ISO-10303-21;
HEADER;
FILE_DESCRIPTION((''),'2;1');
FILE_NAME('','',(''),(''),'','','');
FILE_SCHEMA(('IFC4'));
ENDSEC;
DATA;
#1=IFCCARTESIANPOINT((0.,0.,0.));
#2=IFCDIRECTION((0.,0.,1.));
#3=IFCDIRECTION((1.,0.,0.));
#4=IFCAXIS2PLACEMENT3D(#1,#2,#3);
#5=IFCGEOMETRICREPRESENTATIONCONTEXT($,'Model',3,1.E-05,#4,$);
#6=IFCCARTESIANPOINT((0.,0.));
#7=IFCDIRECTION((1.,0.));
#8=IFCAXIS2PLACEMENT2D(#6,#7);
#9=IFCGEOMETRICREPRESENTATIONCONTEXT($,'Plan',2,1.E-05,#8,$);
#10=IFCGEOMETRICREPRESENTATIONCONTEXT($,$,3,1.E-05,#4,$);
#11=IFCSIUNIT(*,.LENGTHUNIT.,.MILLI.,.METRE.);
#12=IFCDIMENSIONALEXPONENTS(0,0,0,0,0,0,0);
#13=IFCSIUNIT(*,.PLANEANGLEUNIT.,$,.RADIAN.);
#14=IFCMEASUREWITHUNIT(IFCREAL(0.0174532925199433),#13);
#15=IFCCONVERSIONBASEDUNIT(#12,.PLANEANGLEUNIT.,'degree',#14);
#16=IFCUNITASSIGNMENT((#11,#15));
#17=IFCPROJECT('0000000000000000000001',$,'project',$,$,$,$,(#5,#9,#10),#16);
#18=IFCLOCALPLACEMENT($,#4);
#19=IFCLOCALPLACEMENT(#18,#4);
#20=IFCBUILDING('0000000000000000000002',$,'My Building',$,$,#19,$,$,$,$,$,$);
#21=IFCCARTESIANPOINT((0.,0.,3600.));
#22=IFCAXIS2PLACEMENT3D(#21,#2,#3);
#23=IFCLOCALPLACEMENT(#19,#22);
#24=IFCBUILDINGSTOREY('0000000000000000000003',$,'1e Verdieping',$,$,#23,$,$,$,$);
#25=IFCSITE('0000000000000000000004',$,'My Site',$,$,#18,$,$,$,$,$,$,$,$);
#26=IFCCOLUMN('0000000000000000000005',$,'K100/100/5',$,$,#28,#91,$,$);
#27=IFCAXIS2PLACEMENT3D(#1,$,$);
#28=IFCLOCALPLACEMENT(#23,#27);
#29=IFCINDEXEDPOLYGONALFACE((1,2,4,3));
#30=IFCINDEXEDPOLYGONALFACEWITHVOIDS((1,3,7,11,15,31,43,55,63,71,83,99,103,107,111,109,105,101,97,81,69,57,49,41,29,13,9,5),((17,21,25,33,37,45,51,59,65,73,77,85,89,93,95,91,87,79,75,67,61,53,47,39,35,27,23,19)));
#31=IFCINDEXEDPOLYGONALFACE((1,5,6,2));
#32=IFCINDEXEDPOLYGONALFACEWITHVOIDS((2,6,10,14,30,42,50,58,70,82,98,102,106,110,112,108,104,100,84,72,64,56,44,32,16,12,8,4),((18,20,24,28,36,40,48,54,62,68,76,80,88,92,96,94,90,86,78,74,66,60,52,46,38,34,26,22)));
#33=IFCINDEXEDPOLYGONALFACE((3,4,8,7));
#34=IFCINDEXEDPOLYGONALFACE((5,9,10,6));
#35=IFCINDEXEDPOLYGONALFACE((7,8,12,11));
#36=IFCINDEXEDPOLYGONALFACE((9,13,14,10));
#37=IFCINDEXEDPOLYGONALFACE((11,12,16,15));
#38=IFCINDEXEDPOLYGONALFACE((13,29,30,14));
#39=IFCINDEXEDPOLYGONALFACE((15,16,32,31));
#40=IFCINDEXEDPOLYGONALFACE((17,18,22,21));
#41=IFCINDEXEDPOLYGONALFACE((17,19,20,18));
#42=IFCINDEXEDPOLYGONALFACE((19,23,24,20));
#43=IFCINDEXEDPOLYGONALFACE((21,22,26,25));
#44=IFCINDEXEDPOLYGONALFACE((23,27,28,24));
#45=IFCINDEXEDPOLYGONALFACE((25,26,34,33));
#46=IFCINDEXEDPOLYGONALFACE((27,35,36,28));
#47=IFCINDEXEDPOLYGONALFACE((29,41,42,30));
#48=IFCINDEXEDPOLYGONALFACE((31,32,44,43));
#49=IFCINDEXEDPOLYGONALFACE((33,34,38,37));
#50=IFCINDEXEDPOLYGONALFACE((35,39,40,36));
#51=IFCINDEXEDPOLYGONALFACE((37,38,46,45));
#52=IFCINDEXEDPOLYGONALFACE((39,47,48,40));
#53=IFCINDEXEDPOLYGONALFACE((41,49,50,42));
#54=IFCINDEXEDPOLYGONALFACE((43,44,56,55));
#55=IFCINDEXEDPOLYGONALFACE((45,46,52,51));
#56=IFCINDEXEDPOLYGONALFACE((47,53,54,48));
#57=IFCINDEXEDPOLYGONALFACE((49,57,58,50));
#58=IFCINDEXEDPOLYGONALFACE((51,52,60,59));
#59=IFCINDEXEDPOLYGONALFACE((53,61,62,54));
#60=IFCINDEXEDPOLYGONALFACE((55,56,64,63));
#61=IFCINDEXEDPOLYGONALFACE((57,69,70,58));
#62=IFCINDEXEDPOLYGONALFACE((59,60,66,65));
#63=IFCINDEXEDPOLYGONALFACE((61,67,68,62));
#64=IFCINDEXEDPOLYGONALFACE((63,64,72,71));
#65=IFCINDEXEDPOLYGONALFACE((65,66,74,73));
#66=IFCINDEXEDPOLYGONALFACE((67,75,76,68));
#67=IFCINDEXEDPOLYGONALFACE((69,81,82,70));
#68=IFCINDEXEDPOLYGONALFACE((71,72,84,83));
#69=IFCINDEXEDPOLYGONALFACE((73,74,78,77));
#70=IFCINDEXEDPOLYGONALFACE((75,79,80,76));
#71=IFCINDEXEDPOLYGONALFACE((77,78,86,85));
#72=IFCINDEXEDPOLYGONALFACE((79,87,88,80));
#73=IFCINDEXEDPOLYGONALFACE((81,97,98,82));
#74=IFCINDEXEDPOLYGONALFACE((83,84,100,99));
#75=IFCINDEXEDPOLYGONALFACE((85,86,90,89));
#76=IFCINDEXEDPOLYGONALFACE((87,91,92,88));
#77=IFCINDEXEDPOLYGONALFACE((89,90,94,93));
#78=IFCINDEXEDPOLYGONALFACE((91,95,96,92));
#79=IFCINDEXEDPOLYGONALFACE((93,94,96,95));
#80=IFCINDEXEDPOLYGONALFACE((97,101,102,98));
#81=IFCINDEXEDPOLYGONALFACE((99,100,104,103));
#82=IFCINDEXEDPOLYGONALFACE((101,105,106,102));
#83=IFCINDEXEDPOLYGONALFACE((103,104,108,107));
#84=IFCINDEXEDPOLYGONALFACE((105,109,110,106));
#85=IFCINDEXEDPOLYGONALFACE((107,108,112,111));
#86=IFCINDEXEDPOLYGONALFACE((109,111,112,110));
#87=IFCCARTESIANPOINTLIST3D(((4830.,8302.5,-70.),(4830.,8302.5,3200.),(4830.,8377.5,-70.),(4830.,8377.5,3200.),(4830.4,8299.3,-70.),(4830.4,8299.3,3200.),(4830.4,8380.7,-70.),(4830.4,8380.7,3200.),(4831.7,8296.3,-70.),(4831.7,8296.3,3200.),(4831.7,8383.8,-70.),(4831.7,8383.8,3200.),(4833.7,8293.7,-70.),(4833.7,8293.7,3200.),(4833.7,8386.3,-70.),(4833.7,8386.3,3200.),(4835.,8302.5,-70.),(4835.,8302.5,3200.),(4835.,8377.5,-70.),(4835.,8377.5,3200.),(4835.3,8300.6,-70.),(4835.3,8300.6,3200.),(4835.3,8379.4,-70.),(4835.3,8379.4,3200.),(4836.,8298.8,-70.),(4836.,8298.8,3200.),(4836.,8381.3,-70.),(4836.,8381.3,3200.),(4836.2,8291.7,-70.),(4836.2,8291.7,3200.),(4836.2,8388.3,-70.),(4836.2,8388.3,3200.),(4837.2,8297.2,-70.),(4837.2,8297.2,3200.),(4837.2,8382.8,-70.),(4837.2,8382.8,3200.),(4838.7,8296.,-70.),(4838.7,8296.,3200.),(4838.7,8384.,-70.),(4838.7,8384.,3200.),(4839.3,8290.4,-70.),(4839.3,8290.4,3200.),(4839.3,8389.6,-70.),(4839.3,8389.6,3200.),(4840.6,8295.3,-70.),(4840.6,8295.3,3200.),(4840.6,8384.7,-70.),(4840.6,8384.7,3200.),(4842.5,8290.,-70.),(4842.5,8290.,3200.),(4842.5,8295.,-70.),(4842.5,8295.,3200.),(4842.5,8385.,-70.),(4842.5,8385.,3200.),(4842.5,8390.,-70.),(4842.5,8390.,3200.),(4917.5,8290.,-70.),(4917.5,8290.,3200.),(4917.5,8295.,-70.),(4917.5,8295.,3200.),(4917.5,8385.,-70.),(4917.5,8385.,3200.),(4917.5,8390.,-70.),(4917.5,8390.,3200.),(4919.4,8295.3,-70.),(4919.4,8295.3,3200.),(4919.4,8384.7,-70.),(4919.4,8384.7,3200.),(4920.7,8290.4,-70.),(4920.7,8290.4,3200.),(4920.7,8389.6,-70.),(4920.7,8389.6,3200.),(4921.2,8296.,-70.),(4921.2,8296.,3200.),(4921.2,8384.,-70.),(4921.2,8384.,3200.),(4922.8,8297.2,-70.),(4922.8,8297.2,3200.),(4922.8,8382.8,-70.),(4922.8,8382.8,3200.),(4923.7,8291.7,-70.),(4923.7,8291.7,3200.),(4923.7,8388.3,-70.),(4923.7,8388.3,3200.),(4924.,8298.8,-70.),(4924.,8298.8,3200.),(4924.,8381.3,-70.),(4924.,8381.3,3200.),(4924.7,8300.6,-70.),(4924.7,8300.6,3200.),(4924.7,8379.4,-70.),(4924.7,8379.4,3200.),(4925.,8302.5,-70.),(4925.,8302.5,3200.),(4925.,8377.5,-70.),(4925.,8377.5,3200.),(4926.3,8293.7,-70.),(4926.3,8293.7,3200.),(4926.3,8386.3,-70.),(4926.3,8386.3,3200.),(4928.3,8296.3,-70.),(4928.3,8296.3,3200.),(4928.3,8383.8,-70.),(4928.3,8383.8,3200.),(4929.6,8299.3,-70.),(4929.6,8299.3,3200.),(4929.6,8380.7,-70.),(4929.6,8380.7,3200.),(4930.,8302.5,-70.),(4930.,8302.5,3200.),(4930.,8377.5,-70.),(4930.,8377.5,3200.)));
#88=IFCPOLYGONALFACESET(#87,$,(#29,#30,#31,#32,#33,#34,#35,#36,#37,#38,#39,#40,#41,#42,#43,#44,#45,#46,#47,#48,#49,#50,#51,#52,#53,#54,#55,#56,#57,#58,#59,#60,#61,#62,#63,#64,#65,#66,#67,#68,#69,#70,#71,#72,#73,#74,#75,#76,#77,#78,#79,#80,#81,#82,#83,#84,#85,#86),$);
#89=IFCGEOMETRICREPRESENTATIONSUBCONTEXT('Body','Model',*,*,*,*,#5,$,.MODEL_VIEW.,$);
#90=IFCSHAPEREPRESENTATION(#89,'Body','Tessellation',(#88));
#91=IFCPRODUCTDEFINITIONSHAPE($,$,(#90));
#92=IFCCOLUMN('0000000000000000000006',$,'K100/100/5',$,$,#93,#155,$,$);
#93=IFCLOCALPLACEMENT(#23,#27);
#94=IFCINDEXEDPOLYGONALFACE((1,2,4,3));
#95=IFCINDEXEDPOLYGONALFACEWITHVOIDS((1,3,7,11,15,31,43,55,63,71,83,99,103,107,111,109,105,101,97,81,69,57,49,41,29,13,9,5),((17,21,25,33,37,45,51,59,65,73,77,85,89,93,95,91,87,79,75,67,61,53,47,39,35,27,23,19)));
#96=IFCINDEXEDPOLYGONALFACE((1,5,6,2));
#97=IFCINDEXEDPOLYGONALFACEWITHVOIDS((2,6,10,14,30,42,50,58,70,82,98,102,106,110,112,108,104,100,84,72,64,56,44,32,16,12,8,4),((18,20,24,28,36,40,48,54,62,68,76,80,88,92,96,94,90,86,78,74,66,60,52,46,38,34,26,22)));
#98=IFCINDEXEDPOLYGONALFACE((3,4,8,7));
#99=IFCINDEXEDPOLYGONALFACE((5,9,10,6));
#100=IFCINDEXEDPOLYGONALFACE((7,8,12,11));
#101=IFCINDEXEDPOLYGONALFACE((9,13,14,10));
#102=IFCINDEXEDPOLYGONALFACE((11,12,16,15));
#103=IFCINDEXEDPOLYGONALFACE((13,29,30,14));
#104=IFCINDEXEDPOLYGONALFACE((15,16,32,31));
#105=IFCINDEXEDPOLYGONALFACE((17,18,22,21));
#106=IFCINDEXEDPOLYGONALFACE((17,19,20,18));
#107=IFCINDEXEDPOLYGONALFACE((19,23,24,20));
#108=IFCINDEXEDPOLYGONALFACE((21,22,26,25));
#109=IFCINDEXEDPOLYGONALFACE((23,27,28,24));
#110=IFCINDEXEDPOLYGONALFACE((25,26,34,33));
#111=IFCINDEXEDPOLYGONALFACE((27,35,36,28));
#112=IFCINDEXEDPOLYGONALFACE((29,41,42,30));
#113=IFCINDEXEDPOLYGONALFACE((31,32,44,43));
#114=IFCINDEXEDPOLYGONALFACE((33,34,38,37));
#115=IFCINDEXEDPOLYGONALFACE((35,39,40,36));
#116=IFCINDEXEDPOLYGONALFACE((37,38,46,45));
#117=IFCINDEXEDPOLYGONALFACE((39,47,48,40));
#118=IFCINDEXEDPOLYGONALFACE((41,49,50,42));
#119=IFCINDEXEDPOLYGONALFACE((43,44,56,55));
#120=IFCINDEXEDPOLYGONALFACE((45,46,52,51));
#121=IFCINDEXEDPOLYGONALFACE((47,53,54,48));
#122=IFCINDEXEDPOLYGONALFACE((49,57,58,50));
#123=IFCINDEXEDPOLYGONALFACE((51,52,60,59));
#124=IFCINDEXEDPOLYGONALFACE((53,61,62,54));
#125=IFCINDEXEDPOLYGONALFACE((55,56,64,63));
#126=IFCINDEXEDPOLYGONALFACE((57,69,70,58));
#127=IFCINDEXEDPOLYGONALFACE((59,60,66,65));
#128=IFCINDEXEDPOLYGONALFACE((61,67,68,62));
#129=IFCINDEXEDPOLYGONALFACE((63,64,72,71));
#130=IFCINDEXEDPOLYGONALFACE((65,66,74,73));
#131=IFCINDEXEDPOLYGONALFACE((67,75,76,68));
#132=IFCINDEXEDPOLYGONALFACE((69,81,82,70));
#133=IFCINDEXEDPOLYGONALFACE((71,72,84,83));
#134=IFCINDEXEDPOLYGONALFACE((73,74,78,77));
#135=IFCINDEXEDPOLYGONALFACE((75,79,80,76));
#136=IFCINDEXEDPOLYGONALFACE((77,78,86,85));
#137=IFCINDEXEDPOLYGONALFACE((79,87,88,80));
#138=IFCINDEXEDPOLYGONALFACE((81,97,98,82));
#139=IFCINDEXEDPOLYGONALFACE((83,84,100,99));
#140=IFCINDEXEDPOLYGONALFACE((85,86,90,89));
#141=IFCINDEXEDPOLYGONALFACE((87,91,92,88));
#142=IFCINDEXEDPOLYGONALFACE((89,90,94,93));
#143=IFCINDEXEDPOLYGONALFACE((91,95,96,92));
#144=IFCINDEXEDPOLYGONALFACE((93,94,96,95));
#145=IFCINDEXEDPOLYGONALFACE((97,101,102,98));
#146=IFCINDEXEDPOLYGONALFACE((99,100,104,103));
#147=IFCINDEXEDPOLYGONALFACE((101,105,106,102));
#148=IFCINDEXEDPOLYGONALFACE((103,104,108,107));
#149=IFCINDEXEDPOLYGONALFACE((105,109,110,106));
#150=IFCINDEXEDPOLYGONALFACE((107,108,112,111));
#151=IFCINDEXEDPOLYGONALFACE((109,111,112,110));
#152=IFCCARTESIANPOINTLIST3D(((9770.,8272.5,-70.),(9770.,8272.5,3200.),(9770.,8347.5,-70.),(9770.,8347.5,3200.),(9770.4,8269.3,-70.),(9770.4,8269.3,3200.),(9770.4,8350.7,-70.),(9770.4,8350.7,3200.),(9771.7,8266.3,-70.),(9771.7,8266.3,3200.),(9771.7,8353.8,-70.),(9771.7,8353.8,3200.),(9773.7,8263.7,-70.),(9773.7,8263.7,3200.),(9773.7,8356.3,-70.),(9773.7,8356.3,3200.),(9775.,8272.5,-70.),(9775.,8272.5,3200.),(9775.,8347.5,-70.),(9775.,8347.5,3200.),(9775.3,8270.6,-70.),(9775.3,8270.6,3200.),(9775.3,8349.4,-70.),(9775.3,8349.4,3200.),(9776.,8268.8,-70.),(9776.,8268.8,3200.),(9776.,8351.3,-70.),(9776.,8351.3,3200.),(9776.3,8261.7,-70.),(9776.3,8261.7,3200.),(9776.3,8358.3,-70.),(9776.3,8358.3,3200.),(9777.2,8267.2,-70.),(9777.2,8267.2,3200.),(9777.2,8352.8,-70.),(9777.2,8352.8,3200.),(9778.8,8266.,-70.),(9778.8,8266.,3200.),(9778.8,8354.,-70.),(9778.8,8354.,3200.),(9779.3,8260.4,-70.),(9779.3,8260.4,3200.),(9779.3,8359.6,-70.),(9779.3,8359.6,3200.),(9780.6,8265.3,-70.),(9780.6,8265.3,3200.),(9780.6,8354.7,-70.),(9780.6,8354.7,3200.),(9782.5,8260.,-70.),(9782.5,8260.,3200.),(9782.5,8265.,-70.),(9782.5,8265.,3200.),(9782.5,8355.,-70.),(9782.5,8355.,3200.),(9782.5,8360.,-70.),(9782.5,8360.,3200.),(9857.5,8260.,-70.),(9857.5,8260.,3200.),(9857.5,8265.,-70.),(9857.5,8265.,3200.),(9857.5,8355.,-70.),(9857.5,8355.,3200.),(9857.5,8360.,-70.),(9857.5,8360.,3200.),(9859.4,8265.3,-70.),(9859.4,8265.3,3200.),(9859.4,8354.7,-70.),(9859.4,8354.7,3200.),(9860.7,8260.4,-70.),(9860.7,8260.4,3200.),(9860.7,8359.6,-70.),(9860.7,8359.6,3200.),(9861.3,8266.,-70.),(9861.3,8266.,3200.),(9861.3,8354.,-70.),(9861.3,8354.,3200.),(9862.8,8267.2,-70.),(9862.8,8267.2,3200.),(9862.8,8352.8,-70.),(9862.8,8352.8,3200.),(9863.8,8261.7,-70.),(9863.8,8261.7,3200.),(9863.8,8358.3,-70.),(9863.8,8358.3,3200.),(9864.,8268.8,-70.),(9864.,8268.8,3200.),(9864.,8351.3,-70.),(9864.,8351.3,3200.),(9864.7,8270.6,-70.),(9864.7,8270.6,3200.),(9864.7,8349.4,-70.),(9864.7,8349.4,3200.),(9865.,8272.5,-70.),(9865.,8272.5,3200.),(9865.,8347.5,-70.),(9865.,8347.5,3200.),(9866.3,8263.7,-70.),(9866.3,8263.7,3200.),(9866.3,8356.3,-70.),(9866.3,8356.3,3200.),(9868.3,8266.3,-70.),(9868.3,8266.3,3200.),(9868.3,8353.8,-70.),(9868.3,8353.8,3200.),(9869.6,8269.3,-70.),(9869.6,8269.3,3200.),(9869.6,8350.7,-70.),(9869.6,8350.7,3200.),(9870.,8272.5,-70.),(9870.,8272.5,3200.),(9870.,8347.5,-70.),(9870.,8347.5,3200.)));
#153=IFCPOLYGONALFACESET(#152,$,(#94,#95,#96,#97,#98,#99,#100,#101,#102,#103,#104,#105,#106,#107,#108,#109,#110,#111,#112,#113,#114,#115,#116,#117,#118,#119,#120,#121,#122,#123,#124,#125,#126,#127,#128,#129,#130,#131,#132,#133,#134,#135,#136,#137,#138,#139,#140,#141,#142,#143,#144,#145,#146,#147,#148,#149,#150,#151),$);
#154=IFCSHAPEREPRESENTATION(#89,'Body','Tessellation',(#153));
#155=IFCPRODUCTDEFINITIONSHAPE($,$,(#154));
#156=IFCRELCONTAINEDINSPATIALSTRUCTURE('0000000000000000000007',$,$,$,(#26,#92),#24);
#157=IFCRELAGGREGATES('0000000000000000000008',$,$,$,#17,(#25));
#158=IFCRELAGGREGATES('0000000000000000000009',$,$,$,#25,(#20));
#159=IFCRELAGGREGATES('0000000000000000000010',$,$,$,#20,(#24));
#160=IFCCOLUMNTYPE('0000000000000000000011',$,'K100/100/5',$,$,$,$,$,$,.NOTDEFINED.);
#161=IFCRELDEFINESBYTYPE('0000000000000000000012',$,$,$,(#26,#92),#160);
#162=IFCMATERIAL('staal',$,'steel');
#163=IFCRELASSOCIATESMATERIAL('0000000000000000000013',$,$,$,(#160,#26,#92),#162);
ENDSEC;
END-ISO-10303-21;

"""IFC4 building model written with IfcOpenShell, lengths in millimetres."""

from ifc_helpers import new_model, entity, si_unit, converted_unit, frame, origin_with_axes, origin_2d_with_axis, place, context, subcontext, project, spatial, hollow_rectangle, extrude, material, material_profile, profile_set, profile_usage, type_object, element, save


model = new_model("IFC4")

# Units and contexts
model_context = context("Model", 3, precision=1e-05, world=origin_with_axes())
plan_context = context("Plan", 2, precision=1e-05, world=origin_2d_with_axis())
context_of_model = context(None, 3, precision=1e-05, world=origin_with_axes())
body_context = subcontext(model_context, "Body", "Model", "MODEL_VIEW")
ifc_project = project(units=[si_unit("LENGTHUNIT", "METRE", prefix="MILLI"), converted_unit("PLANEANGLEUNIT", "degree", entity("IfcReal", 0.0174532925199433), si_unit("PLANEANGLEUNIT", "RADIAN"), dimensions=[0, 0, 0, 0, 0, 0, 0])], contexts=[model_context, plan_context, context_of_model])

# Site, building, storey
site_placement = place(None, origin_with_axes())
site = spatial("IfcSite", under=ifc_project, at=site_placement, Name="My Site")
building_placement = place(site_placement, origin_with_axes())
building = spatial("IfcBuilding", under=site, at=building_placement, Name="My Building")
storey_placement = place(building_placement, frame((0.0, 0.0, 3600.0), z_axis=(0.0, 0.0, 1.0), x_axis=(1.0, 0.0, 0.0)))
storey = spatial("IfcBuildingStorey", under=building, at=storey_placement, Name="1e Verdieping")

# Columns
ifc_material_1 = material(Name="staal", Category="steel")
ifc_material_profile_1 = material_profile(ifc_material_1, hollow_rectangle(XDim=100.0, YDim=100.0, WallThickness=5.0, InnerFilletRadius=7.5, OuterFilletRadius=12.5))
ifc_profile_set_1 = profile_set([ifc_material_profile_1], Name="K100/100/5")
column_type_1 = type_object("IfcColumnType", Name="K100/100/5", PredefinedType="NOTDEFINED", material=ifc_profile_set_1)
ifc_profile_usage_1 = profile_usage(ifc_profile_set_1, cardinal=5)
column_1_placement = place(storey_placement, frame((4880.0, 8340.0, -70.0), z_axis=(0.0, 0.0, 1.0), x_axis=(1.0, 0.0, 0.0)))
element("IfcColumn", 1, at=column_1_placement, inside=storey, type_object=column_type_1, material=ifc_profile_usage_1, Name="K100/100/5", context=body_context, shape_type="SweptSolid", body=[
    extrude(hollow_rectangle(XDim=100.0, YDim=100.0, WallThickness=5.0, InnerFilletRadius=7.5, OuterFilletRadius=12.5), origin_with_axes(), (0.0, 0.0, 1.0), 3270.0),
])
ifc_profile_usage_2 = profile_usage(ifc_profile_set_1, cardinal=5)
column_2_placement = place(storey_placement, frame((9820.0, 8310.0, -70.0), z_axis=(0.0, 0.0, 1.0), x_axis=(1.0, 0.0, 0.0)))
element("IfcColumn", 2, at=column_2_placement, inside=storey, type_object=column_type_1, material=ifc_profile_usage_2, Name="K100/100/5", context=body_context, shape_type="SweptSolid", body=[
    extrude(hollow_rectangle(XDim=100.0, YDim=100.0, WallThickness=5.0, InnerFilletRadius=7.5, OuterFilletRadius=12.5), origin_with_axes(), (0.0, 0.0, 1.0), 3270.0),
])

save(model, "model.ifc")
